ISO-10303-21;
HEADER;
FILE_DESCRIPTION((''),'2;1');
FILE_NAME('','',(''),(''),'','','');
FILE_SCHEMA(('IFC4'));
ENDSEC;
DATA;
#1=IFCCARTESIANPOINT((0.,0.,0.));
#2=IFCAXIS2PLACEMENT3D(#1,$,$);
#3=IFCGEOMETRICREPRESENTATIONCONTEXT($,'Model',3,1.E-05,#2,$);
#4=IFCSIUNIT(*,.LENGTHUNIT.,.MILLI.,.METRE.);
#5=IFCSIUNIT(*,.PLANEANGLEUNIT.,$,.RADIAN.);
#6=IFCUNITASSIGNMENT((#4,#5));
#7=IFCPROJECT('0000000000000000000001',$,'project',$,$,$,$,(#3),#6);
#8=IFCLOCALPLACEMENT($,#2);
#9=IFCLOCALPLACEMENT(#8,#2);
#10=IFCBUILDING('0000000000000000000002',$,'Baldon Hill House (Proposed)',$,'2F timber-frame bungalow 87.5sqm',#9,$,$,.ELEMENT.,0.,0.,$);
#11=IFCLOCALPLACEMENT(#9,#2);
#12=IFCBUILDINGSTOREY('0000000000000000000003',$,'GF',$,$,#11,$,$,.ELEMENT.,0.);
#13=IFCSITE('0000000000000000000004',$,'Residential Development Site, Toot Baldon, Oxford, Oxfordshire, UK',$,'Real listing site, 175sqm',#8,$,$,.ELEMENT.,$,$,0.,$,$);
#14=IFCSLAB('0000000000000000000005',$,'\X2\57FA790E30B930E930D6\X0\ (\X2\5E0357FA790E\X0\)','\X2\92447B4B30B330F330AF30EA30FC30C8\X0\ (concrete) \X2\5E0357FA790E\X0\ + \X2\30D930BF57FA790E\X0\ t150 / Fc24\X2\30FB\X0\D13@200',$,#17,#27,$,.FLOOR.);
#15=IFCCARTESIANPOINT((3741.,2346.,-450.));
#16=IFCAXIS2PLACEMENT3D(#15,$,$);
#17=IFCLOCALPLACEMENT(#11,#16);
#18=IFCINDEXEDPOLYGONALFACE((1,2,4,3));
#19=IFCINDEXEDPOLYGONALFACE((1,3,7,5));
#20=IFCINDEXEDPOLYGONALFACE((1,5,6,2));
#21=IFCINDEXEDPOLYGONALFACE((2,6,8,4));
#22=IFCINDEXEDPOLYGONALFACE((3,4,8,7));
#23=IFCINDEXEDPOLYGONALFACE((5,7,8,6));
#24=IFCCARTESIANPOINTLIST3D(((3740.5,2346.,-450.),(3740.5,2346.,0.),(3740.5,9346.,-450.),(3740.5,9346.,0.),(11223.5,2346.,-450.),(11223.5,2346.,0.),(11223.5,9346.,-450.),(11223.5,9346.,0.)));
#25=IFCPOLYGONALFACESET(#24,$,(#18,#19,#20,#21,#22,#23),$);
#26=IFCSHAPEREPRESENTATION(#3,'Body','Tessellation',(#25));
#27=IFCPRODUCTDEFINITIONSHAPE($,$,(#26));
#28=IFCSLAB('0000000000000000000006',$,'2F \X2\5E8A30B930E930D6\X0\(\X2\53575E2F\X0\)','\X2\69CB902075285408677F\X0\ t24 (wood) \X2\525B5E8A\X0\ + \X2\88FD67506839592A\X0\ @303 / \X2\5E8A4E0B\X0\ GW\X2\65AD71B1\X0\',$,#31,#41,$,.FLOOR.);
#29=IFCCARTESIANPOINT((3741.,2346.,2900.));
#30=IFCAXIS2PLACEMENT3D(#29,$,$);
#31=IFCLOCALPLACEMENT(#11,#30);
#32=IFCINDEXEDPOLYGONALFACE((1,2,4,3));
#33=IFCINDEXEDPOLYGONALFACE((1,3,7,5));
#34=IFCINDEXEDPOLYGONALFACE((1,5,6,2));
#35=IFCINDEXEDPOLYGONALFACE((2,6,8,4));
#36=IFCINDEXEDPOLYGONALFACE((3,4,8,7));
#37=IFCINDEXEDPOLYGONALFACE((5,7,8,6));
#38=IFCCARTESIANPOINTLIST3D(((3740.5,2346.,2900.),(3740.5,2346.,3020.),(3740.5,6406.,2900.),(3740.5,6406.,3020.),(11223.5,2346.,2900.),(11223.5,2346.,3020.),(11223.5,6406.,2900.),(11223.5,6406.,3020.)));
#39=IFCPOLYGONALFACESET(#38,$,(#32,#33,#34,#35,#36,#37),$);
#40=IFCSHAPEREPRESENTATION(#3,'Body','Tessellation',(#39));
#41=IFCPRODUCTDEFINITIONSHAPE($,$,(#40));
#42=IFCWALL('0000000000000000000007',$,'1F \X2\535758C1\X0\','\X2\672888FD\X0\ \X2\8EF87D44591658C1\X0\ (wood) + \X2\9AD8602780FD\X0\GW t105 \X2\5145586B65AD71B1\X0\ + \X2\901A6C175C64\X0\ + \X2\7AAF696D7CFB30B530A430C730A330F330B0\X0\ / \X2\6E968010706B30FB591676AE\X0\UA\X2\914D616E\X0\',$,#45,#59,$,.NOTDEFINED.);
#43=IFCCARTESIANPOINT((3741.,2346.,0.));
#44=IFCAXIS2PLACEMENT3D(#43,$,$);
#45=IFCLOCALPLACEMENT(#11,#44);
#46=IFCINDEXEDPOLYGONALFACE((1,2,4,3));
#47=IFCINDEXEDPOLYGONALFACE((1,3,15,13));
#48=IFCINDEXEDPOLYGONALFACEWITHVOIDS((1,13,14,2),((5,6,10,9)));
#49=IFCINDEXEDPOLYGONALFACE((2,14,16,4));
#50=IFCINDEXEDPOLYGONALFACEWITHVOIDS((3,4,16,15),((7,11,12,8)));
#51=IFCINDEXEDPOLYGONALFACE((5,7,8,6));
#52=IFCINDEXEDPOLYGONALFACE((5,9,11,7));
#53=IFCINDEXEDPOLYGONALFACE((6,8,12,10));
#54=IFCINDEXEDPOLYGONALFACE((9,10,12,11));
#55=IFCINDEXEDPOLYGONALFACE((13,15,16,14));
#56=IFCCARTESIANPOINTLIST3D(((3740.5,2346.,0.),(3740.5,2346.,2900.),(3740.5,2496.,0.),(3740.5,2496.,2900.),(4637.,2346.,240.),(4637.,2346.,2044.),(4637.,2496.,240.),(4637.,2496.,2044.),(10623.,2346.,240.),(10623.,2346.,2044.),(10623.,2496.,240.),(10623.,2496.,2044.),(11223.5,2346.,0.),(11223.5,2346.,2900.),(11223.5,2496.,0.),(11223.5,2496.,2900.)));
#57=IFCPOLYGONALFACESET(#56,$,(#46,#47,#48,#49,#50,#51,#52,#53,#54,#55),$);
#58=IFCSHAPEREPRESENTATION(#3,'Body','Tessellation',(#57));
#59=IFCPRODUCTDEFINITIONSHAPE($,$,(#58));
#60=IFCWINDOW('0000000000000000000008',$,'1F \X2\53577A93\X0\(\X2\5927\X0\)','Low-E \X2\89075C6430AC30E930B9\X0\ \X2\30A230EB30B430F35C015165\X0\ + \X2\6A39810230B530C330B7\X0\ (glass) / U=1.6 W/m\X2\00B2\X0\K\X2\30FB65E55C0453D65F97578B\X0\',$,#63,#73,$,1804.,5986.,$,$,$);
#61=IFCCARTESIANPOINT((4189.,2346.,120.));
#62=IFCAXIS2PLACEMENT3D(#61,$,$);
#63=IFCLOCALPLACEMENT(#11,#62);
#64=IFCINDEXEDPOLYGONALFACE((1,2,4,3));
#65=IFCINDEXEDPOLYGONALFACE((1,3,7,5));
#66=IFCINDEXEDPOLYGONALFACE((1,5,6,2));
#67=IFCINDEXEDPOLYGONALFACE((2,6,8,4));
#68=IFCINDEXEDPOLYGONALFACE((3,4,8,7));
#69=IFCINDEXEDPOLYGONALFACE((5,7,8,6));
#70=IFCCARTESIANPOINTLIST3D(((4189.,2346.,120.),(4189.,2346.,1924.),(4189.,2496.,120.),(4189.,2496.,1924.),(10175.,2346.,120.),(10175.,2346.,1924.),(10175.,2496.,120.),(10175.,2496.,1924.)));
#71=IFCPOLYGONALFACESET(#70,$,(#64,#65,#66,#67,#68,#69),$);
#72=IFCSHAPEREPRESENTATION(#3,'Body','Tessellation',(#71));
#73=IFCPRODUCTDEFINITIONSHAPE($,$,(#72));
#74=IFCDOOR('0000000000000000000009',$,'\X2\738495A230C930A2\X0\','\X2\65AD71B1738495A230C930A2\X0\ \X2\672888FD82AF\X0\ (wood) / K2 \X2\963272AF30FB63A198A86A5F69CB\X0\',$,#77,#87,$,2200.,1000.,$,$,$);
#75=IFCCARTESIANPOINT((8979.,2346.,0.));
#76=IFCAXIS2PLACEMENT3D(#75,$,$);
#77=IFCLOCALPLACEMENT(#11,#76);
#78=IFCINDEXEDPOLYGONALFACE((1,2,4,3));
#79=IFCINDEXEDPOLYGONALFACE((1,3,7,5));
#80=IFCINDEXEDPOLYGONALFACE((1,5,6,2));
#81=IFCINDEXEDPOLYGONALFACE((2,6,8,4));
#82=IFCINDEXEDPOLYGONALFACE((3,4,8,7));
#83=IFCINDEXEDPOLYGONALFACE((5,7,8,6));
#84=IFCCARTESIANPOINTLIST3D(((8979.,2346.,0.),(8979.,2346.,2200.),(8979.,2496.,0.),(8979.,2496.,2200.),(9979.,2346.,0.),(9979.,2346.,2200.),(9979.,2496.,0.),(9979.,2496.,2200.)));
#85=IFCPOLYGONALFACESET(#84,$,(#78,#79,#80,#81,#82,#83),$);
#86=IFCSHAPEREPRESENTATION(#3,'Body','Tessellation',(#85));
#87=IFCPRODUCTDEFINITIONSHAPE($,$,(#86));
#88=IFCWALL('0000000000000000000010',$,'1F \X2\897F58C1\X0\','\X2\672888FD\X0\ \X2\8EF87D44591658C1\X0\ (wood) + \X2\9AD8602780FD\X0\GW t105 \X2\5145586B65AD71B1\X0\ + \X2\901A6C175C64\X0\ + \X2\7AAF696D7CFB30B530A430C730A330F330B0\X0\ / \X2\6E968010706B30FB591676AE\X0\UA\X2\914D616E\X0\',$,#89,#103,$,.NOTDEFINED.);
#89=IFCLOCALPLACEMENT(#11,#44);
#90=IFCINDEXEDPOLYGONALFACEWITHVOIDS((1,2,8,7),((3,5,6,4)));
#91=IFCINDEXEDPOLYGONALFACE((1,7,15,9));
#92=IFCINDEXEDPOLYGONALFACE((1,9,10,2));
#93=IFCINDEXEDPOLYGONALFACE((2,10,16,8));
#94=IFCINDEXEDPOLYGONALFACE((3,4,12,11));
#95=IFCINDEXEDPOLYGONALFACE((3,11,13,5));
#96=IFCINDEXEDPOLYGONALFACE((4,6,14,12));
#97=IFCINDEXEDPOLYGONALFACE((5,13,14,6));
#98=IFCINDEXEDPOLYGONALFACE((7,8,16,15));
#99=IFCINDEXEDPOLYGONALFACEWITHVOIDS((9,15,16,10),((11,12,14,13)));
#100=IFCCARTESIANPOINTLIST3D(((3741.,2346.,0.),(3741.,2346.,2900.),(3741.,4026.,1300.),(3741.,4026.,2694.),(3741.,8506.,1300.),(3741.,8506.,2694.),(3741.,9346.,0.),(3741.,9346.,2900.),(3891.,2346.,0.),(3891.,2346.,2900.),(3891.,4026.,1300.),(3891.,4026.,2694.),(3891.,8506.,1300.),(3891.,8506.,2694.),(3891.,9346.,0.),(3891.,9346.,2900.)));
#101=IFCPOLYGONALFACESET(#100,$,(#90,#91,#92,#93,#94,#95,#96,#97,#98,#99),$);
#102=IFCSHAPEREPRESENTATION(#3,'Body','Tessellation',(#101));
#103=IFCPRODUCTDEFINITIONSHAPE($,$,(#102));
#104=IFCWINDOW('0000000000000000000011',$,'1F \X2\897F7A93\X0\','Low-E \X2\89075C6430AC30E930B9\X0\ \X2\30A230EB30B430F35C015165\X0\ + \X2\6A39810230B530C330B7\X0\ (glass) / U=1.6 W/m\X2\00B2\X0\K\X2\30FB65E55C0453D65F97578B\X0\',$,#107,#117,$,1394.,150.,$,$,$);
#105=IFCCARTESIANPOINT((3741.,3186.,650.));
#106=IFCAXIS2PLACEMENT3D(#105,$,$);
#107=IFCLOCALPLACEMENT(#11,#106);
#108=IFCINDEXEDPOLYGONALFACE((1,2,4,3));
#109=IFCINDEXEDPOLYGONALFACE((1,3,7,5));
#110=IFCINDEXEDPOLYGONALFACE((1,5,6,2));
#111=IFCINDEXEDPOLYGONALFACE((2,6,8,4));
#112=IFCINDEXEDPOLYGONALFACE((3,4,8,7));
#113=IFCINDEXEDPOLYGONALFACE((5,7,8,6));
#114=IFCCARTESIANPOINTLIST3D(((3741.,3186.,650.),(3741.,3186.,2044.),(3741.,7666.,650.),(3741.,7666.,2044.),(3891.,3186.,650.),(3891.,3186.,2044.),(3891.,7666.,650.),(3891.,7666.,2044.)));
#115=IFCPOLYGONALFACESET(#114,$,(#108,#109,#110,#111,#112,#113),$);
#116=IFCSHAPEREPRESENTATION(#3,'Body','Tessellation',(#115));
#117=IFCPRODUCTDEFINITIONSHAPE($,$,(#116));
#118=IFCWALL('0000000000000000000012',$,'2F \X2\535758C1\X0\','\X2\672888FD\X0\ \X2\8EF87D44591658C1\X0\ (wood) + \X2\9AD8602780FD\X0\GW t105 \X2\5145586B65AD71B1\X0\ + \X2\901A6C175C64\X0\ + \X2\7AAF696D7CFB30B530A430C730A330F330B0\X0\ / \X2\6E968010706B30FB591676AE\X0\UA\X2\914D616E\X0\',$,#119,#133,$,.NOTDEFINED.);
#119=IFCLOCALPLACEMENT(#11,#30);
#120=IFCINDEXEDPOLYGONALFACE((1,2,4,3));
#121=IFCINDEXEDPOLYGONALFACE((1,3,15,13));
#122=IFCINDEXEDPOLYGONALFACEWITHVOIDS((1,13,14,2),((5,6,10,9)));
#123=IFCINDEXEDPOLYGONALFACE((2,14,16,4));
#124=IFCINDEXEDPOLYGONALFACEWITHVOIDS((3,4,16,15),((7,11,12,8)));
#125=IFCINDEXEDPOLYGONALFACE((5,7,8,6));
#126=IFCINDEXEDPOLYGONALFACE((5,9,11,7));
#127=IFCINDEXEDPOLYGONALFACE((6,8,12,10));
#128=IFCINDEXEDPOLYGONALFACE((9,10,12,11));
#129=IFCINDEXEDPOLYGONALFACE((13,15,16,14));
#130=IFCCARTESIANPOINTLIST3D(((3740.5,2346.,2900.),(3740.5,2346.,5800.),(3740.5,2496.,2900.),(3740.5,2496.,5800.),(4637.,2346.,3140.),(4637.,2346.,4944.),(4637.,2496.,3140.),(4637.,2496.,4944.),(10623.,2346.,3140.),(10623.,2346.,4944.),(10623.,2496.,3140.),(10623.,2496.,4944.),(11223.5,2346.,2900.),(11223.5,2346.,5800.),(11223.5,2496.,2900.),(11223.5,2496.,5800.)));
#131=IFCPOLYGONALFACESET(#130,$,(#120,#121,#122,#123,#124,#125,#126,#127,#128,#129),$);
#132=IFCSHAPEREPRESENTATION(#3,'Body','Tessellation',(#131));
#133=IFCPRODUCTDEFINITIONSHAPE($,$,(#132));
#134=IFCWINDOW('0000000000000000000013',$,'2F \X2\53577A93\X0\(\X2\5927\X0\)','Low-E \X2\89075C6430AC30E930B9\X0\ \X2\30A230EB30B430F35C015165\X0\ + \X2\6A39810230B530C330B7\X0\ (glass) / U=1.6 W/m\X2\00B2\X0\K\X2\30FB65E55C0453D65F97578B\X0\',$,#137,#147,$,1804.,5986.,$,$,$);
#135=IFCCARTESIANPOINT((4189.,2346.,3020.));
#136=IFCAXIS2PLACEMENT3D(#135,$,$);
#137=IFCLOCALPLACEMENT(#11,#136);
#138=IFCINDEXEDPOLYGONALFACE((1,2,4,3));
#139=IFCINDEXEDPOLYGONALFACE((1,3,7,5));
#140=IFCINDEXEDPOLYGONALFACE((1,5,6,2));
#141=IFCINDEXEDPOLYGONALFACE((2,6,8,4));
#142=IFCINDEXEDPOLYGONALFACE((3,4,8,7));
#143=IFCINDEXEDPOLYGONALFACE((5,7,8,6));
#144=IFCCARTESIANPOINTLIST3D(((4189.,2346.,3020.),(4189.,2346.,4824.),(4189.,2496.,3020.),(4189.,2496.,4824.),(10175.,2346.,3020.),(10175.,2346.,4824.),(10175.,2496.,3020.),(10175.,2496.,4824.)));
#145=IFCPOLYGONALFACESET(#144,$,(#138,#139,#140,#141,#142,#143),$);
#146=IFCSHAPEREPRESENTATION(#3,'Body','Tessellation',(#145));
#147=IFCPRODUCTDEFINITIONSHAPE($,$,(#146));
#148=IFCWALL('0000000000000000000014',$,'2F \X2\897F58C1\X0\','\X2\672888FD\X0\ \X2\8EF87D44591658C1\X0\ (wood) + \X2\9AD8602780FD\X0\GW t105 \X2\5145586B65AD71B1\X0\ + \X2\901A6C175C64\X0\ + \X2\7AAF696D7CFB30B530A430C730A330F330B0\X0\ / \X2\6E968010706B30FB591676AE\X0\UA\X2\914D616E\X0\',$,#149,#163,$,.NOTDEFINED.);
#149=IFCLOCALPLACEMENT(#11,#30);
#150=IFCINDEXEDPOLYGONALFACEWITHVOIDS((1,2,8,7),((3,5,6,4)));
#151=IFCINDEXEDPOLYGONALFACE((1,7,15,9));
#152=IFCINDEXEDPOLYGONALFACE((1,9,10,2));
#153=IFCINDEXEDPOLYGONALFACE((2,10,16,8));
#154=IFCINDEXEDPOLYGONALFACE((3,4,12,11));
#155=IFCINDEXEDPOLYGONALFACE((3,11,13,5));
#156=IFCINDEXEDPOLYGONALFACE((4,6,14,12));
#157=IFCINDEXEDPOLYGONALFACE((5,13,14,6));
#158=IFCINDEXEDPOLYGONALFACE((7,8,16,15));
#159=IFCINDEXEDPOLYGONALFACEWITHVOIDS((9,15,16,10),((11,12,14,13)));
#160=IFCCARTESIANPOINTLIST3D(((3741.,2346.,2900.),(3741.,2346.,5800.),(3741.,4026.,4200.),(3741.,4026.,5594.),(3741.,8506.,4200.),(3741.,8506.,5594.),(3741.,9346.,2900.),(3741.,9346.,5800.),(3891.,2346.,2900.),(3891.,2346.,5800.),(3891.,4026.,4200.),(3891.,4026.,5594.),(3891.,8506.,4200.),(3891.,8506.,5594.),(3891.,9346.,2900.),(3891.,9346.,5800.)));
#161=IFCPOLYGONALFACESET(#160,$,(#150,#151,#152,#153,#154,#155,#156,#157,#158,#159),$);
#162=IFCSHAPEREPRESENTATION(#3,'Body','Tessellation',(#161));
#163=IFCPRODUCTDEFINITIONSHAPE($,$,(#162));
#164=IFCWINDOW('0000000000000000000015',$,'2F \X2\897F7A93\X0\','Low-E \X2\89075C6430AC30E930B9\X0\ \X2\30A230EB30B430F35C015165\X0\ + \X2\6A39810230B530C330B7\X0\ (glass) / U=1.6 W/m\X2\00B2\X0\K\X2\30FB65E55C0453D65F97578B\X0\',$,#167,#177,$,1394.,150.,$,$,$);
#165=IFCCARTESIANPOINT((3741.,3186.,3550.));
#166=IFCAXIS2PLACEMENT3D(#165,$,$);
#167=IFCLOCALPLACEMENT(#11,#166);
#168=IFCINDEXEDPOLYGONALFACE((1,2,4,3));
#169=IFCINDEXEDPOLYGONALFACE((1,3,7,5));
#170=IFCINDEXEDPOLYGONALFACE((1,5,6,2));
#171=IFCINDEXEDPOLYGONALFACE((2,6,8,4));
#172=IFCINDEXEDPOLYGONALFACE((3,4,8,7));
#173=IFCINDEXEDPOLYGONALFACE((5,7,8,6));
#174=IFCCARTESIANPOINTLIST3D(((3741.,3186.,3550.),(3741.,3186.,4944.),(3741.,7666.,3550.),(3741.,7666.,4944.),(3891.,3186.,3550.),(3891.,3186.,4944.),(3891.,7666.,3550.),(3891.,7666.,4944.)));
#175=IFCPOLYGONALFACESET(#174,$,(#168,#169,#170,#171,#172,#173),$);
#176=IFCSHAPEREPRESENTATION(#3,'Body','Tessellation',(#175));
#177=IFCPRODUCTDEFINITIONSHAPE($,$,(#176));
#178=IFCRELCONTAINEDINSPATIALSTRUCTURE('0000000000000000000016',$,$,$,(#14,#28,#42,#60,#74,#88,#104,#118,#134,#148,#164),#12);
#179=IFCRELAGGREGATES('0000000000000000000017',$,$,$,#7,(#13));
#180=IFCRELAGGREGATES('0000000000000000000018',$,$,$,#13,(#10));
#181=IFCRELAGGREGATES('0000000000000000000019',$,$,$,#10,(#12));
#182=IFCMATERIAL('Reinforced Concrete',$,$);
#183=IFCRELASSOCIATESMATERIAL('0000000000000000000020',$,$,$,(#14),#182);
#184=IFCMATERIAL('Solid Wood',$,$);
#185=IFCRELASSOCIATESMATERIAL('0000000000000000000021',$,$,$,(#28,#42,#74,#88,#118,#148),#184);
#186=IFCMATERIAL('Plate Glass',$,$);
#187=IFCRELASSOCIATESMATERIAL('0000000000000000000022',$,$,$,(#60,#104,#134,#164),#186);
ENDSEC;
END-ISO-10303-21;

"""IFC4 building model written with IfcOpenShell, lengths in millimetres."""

from ifc_helpers import new_model, si_unit, frame, frame_2d, origin, place, context, project, spatial, rectangle, extrude, material, element, fill, save


model = new_model("IFC4")

# Units and contexts
model_context = context("Model", 3, precision=1e-05, world=origin())
ifc_project = project(units=[si_unit("LENGTHUNIT", "METRE", prefix="MILLI"), si_unit("PLANEANGLEUNIT", "RADIAN")], contexts=[model_context])

# Site, building, storey
site_placement = place(None, origin())
site = spatial("IfcSite", under=ifc_project, at=site_placement, Name="Residential Development Site, Toot Baldon, Oxford, Oxfordshire, UK", ObjectType="Real listing site, 175sqm", CompositionType="ELEMENT", RefElevation=0.0)
building_placement = place(site_placement, origin())
building = spatial("IfcBuilding", under=site, at=building_placement, Name="Baldon Hill House (Proposed)", ObjectType="2F timber-frame bungalow 87.5sqm", CompositionType="ELEMENT", ElevationOfRefHeight=0.0, ElevationOfTerrain=0.0)
storey_placement = place(building_placement, origin())
storey = spatial("IfcBuildingStorey", under=building, at=storey_placement, Name="GF", CompositionType="ELEMENT", Elevation=0.0)

# Slabs
ifc_material_1 = material(Name="Reinforced Concrete")
slab_1_placement = place(storey_placement, frame((3741.0, 2346.0, -450.0)))
element("IfcSlab", 1, at=slab_1_placement, inside=storey, material=ifc_material_1, Name="基礎スラブ (布基礎)", Description="鉄筋コンクリート (concrete) 布基礎 + ベタ基礎 t150 / Fc24・D13@200", PredefinedType="FLOOR", context=model_context, shape_type="SweptSolid", body=[
    extrude(rectangle(XDim=7483.0, YDim=7000.0, at=frame_2d((3741.0, 3500.0))), frame((3741.0, 2346.0, -450.0)), (0.0, 0.0, 1.0), 450.0),
])
ifc_material_2 = material(Name="Solid Wood")
slab_2_placement = place(storey_placement, frame((3741.0, 2346.0, 2900.0)))
element("IfcSlab", 2, at=slab_2_placement, inside=storey, material=ifc_material_2, Name="2F 床スラブ(南帯)", Description="構造用合板 t24 (wood) 剛床 + 製材根太 @303 / 床下 GW断熱", PredefinedType="FLOOR", context=model_context, shape_type="SweptSolid", body=[
    extrude(rectangle(XDim=7483.0, YDim=4060.0, at=frame_2d((3741.0, 2030.0))), frame((3741.0, 2346.0, 2900.0)), (0.0, 0.0, 1.0), 120.0),
])

# Wall, openings, window, door
wall_1_placement = place(storey_placement, frame((3741.0, 2346.0, 0.0)))
wall_1 = element("IfcWall", 3, at=wall_1_placement, inside=storey, material=ifc_material_2, Name="1F 南壁", Description="木製 軸組外壁 (wood) + 高性能GW t105 充填断熱 + 通気層 + 窯業系サイディング / 準耐火・外皮UA配慮", PredefinedType="NOTDEFINED", context=model_context, shape_type="SweptSolid", body=[
    extrude(rectangle(XDim=7483.0, YDim=150.0, at=frame_2d((3741.0, 75.0))), frame((3741.0, 2346.0, 0.0)), (0.0, 0.0, 1.0), 2900.0),
])
opening_1_placement = place(storey_placement, frame((4189.0, 2346.0, 120.0)))
opening_1 = element("IfcOpeningElement", 4, at=opening_1_placement, cuts=wall_1, PredefinedType="NOTDEFINED", context=model_context, shape_type="SweptSolid", body=[
    extrude(rectangle(XDim=5986.0, YDim=150.0, at=frame_2d((2993.0, 75.0))), frame((4189.0, 2346.0, 120.0)), (0.0, 0.0, 1.0), 1804.0),
])
opening_2_placement = place(storey_placement, frame((8979.0, 2346.0, 0.0)))
opening_2 = element("IfcOpeningElement", 5, at=opening_2_placement, cuts=wall_1, PredefinedType="NOTDEFINED", context=model_context, shape_type="SweptSolid", body=[
    extrude(rectangle(XDim=1000.0, YDim=150.0, at=frame_2d((500.0, 75.0))), frame((8979.0, 2346.0, 0.0)), (0.0, 0.0, 1.0), 2200.0),
])
ifc_material_3 = material(Name="Plate Glass")
window_1_placement = place(storey_placement, frame((4189.0, 2346.0, 120.0)))
window_1 = element("IfcWindow", 6, at=window_1_placement, inside=storey, material=ifc_material_3, Name="1F 南窓(大)", Description="Low-E 複層ガラス アルゴン封入 + 樹脂サッシ (glass) / U=1.6 W/m²K・日射取得型", OverallHeight=1804.0, OverallWidth=5986.0, context=model_context, shape_type="SweptSolid", body=[
    extrude(rectangle(XDim=5986.0, YDim=150.0, at=frame_2d((2993.0, 75.0))), frame((4189.0, 2346.0, 120.0)), (0.0, 0.0, 1.0), 1804.0),
])
fill(opening_1, window_1)
door_placement = place(storey_placement, frame((8979.0, 2346.0, 0.0)))
door = element("IfcDoor", 7, at=door_placement, inside=storey, material=ifc_material_2, Name="玄関ドア", Description="断熱玄関ドア 木製芯 (wood) / K2 防犯・採風機構", OverallHeight=2200.0, OverallWidth=1000.0, context=model_context, shape_type="SweptSolid", body=[
    extrude(rectangle(XDim=1000.0, YDim=150.0, at=frame_2d((500.0, 75.0))), frame((8979.0, 2346.0, 0.0)), (0.0, 0.0, 1.0), 2200.0),
])
fill(opening_2, door)

# Wall, opening, window
wall_2_placement = place(storey_placement, frame((3741.0, 2346.0, 0.0)))
wall_2 = element("IfcWall", 8, at=wall_2_placement, inside=storey, material=ifc_material_2, Name="1F 西壁", Description="木製 軸組外壁 (wood) + 高性能GW t105 充填断熱 + 通気層 + 窯業系サイディング / 準耐火・外皮UA配慮", PredefinedType="NOTDEFINED", context=model_context, shape_type="SweptSolid", body=[
    extrude(rectangle(XDim=150.0, YDim=7000.0, at=frame_2d((75.0, 3500.0))), frame((3741.0, 2346.0, 0.0)), (0.0, 0.0, 1.0), 2900.0),
])
opening_3_placement = place(storey_placement, frame((3741.0, 3186.0, 650.0)))
opening_3 = element("IfcOpeningElement", 9, at=opening_3_placement, cuts=wall_2, PredefinedType="NOTDEFINED", context=model_context, shape_type="SweptSolid", body=[
    extrude(rectangle(XDim=150.0, YDim=4480.0, at=frame_2d((75.0, 2240.0))), frame((3741.0, 3186.0, 650.0)), (0.0, 0.0, 1.0), 1394.0),
])
window_2_placement = place(storey_placement, frame((3741.0, 3186.0, 650.0)))
window_2 = element("IfcWindow", 10, at=window_2_placement, inside=storey, material=ifc_material_3, Name="1F 西窓", Description="Low-E 複層ガラス アルゴン封入 + 樹脂サッシ (glass) / U=1.6 W/m²K・日射取得型", OverallHeight=1394.0, OverallWidth=150.0, context=model_context, shape_type="SweptSolid", body=[
    extrude(rectangle(XDim=150.0, YDim=4480.0, at=frame_2d((75.0, 2240.0))), frame((3741.0, 3186.0, 650.0)), (0.0, 0.0, 1.0), 1394.0),
])
fill(opening_3, window_2)

# Walls, openings, windows
wall_3_placement = place(storey_placement, frame((3741.0, 2346.0, 2900.0)))
wall_3 = element("IfcWall", 11, at=wall_3_placement, inside=storey, material=ifc_material_2, Name="2F 南壁", Description="木製 軸組外壁 (wood) + 高性能GW t105 充填断熱 + 通気層 + 窯業系サイディング / 準耐火・外皮UA配慮", PredefinedType="NOTDEFINED", context=model_context, shape_type="SweptSolid", body=[
    extrude(rectangle(XDim=7483.0, YDim=150.0, at=frame_2d((3741.0, 75.0))), frame((3741.0, 2346.0, 2900.0)), (0.0, 0.0, 1.0), 2900.0),
])
opening_4_placement = place(storey_placement, frame((4189.0, 2346.0, 3020.0)))
opening_4 = element("IfcOpeningElement", 12, at=opening_4_placement, cuts=wall_3, PredefinedType="NOTDEFINED", context=model_context, shape_type="SweptSolid", body=[
    extrude(rectangle(XDim=5986.0, YDim=150.0, at=frame_2d((2993.0, 75.0))), frame((4189.0, 2346.0, 3020.0)), (0.0, 0.0, 1.0), 1804.0),
])
window_3_placement = place(storey_placement, frame((4189.0, 2346.0, 3020.0)))
window_3 = element("IfcWindow", 13, at=window_3_placement, inside=storey, material=ifc_material_3, Name="2F 南窓(大)", Description="Low-E 複層ガラス アルゴン封入 + 樹脂サッシ (glass) / U=1.6 W/m²K・日射取得型", OverallHeight=1804.0, OverallWidth=5986.0, context=model_context, shape_type="SweptSolid", body=[
    extrude(rectangle(XDim=5986.0, YDim=150.0, at=frame_2d((2993.0, 75.0))), frame((4189.0, 2346.0, 3020.0)), (0.0, 0.0, 1.0), 1804.0),
])
fill(opening_4, window_3)
wall_4_placement = place(storey_placement, frame((3741.0, 2346.0, 2900.0)))
wall_4 = element("IfcWall", 14, at=wall_4_placement, inside=storey, material=ifc_material_2, Name="2F 西壁", Description="木製 軸組外壁 (wood) + 高性能GW t105 充填断熱 + 通気層 + 窯業系サイディング / 準耐火・外皮UA配慮", PredefinedType="NOTDEFINED", context=model_context, shape_type="SweptSolid", body=[
    extrude(rectangle(XDim=150.0, YDim=7000.0, at=frame_2d((75.0, 3500.0))), frame((3741.0, 2346.0, 2900.0)), (0.0, 0.0, 1.0), 2900.0),
])
opening_5_placement = place(storey_placement, frame((3741.0, 3186.0, 3550.0)))
opening_5 = element("IfcOpeningElement", 15, at=opening_5_placement, cuts=wall_4, PredefinedType="NOTDEFINED", context=model_context, shape_type="SweptSolid", body=[
    extrude(rectangle(XDim=150.0, YDim=4480.0, at=frame_2d((75.0, 2240.0))), frame((3741.0, 3186.0, 3550.0)), (0.0, 0.0, 1.0), 1394.0),
])
window_4_placement = place(storey_placement, frame((3741.0, 3186.0, 3550.0)))
window_4 = element("IfcWindow", 16, at=window_4_placement, inside=storey, material=ifc_material_3, Name="2F 西窓", Description="Low-E 複層ガラス アルゴン封入 + 樹脂サッシ (glass) / U=1.6 W/m²K・日射取得型", OverallHeight=1394.0, OverallWidth=150.0, context=model_context, shape_type="SweptSolid", body=[
    extrude(rectangle(XDim=150.0, YDim=4480.0, at=frame_2d((75.0, 2240.0))), frame((3741.0, 3186.0, 3550.0)), (0.0, 0.0, 1.0), 1394.0),
])
fill(opening_5, window_4)

save(model, "model.ifc")
